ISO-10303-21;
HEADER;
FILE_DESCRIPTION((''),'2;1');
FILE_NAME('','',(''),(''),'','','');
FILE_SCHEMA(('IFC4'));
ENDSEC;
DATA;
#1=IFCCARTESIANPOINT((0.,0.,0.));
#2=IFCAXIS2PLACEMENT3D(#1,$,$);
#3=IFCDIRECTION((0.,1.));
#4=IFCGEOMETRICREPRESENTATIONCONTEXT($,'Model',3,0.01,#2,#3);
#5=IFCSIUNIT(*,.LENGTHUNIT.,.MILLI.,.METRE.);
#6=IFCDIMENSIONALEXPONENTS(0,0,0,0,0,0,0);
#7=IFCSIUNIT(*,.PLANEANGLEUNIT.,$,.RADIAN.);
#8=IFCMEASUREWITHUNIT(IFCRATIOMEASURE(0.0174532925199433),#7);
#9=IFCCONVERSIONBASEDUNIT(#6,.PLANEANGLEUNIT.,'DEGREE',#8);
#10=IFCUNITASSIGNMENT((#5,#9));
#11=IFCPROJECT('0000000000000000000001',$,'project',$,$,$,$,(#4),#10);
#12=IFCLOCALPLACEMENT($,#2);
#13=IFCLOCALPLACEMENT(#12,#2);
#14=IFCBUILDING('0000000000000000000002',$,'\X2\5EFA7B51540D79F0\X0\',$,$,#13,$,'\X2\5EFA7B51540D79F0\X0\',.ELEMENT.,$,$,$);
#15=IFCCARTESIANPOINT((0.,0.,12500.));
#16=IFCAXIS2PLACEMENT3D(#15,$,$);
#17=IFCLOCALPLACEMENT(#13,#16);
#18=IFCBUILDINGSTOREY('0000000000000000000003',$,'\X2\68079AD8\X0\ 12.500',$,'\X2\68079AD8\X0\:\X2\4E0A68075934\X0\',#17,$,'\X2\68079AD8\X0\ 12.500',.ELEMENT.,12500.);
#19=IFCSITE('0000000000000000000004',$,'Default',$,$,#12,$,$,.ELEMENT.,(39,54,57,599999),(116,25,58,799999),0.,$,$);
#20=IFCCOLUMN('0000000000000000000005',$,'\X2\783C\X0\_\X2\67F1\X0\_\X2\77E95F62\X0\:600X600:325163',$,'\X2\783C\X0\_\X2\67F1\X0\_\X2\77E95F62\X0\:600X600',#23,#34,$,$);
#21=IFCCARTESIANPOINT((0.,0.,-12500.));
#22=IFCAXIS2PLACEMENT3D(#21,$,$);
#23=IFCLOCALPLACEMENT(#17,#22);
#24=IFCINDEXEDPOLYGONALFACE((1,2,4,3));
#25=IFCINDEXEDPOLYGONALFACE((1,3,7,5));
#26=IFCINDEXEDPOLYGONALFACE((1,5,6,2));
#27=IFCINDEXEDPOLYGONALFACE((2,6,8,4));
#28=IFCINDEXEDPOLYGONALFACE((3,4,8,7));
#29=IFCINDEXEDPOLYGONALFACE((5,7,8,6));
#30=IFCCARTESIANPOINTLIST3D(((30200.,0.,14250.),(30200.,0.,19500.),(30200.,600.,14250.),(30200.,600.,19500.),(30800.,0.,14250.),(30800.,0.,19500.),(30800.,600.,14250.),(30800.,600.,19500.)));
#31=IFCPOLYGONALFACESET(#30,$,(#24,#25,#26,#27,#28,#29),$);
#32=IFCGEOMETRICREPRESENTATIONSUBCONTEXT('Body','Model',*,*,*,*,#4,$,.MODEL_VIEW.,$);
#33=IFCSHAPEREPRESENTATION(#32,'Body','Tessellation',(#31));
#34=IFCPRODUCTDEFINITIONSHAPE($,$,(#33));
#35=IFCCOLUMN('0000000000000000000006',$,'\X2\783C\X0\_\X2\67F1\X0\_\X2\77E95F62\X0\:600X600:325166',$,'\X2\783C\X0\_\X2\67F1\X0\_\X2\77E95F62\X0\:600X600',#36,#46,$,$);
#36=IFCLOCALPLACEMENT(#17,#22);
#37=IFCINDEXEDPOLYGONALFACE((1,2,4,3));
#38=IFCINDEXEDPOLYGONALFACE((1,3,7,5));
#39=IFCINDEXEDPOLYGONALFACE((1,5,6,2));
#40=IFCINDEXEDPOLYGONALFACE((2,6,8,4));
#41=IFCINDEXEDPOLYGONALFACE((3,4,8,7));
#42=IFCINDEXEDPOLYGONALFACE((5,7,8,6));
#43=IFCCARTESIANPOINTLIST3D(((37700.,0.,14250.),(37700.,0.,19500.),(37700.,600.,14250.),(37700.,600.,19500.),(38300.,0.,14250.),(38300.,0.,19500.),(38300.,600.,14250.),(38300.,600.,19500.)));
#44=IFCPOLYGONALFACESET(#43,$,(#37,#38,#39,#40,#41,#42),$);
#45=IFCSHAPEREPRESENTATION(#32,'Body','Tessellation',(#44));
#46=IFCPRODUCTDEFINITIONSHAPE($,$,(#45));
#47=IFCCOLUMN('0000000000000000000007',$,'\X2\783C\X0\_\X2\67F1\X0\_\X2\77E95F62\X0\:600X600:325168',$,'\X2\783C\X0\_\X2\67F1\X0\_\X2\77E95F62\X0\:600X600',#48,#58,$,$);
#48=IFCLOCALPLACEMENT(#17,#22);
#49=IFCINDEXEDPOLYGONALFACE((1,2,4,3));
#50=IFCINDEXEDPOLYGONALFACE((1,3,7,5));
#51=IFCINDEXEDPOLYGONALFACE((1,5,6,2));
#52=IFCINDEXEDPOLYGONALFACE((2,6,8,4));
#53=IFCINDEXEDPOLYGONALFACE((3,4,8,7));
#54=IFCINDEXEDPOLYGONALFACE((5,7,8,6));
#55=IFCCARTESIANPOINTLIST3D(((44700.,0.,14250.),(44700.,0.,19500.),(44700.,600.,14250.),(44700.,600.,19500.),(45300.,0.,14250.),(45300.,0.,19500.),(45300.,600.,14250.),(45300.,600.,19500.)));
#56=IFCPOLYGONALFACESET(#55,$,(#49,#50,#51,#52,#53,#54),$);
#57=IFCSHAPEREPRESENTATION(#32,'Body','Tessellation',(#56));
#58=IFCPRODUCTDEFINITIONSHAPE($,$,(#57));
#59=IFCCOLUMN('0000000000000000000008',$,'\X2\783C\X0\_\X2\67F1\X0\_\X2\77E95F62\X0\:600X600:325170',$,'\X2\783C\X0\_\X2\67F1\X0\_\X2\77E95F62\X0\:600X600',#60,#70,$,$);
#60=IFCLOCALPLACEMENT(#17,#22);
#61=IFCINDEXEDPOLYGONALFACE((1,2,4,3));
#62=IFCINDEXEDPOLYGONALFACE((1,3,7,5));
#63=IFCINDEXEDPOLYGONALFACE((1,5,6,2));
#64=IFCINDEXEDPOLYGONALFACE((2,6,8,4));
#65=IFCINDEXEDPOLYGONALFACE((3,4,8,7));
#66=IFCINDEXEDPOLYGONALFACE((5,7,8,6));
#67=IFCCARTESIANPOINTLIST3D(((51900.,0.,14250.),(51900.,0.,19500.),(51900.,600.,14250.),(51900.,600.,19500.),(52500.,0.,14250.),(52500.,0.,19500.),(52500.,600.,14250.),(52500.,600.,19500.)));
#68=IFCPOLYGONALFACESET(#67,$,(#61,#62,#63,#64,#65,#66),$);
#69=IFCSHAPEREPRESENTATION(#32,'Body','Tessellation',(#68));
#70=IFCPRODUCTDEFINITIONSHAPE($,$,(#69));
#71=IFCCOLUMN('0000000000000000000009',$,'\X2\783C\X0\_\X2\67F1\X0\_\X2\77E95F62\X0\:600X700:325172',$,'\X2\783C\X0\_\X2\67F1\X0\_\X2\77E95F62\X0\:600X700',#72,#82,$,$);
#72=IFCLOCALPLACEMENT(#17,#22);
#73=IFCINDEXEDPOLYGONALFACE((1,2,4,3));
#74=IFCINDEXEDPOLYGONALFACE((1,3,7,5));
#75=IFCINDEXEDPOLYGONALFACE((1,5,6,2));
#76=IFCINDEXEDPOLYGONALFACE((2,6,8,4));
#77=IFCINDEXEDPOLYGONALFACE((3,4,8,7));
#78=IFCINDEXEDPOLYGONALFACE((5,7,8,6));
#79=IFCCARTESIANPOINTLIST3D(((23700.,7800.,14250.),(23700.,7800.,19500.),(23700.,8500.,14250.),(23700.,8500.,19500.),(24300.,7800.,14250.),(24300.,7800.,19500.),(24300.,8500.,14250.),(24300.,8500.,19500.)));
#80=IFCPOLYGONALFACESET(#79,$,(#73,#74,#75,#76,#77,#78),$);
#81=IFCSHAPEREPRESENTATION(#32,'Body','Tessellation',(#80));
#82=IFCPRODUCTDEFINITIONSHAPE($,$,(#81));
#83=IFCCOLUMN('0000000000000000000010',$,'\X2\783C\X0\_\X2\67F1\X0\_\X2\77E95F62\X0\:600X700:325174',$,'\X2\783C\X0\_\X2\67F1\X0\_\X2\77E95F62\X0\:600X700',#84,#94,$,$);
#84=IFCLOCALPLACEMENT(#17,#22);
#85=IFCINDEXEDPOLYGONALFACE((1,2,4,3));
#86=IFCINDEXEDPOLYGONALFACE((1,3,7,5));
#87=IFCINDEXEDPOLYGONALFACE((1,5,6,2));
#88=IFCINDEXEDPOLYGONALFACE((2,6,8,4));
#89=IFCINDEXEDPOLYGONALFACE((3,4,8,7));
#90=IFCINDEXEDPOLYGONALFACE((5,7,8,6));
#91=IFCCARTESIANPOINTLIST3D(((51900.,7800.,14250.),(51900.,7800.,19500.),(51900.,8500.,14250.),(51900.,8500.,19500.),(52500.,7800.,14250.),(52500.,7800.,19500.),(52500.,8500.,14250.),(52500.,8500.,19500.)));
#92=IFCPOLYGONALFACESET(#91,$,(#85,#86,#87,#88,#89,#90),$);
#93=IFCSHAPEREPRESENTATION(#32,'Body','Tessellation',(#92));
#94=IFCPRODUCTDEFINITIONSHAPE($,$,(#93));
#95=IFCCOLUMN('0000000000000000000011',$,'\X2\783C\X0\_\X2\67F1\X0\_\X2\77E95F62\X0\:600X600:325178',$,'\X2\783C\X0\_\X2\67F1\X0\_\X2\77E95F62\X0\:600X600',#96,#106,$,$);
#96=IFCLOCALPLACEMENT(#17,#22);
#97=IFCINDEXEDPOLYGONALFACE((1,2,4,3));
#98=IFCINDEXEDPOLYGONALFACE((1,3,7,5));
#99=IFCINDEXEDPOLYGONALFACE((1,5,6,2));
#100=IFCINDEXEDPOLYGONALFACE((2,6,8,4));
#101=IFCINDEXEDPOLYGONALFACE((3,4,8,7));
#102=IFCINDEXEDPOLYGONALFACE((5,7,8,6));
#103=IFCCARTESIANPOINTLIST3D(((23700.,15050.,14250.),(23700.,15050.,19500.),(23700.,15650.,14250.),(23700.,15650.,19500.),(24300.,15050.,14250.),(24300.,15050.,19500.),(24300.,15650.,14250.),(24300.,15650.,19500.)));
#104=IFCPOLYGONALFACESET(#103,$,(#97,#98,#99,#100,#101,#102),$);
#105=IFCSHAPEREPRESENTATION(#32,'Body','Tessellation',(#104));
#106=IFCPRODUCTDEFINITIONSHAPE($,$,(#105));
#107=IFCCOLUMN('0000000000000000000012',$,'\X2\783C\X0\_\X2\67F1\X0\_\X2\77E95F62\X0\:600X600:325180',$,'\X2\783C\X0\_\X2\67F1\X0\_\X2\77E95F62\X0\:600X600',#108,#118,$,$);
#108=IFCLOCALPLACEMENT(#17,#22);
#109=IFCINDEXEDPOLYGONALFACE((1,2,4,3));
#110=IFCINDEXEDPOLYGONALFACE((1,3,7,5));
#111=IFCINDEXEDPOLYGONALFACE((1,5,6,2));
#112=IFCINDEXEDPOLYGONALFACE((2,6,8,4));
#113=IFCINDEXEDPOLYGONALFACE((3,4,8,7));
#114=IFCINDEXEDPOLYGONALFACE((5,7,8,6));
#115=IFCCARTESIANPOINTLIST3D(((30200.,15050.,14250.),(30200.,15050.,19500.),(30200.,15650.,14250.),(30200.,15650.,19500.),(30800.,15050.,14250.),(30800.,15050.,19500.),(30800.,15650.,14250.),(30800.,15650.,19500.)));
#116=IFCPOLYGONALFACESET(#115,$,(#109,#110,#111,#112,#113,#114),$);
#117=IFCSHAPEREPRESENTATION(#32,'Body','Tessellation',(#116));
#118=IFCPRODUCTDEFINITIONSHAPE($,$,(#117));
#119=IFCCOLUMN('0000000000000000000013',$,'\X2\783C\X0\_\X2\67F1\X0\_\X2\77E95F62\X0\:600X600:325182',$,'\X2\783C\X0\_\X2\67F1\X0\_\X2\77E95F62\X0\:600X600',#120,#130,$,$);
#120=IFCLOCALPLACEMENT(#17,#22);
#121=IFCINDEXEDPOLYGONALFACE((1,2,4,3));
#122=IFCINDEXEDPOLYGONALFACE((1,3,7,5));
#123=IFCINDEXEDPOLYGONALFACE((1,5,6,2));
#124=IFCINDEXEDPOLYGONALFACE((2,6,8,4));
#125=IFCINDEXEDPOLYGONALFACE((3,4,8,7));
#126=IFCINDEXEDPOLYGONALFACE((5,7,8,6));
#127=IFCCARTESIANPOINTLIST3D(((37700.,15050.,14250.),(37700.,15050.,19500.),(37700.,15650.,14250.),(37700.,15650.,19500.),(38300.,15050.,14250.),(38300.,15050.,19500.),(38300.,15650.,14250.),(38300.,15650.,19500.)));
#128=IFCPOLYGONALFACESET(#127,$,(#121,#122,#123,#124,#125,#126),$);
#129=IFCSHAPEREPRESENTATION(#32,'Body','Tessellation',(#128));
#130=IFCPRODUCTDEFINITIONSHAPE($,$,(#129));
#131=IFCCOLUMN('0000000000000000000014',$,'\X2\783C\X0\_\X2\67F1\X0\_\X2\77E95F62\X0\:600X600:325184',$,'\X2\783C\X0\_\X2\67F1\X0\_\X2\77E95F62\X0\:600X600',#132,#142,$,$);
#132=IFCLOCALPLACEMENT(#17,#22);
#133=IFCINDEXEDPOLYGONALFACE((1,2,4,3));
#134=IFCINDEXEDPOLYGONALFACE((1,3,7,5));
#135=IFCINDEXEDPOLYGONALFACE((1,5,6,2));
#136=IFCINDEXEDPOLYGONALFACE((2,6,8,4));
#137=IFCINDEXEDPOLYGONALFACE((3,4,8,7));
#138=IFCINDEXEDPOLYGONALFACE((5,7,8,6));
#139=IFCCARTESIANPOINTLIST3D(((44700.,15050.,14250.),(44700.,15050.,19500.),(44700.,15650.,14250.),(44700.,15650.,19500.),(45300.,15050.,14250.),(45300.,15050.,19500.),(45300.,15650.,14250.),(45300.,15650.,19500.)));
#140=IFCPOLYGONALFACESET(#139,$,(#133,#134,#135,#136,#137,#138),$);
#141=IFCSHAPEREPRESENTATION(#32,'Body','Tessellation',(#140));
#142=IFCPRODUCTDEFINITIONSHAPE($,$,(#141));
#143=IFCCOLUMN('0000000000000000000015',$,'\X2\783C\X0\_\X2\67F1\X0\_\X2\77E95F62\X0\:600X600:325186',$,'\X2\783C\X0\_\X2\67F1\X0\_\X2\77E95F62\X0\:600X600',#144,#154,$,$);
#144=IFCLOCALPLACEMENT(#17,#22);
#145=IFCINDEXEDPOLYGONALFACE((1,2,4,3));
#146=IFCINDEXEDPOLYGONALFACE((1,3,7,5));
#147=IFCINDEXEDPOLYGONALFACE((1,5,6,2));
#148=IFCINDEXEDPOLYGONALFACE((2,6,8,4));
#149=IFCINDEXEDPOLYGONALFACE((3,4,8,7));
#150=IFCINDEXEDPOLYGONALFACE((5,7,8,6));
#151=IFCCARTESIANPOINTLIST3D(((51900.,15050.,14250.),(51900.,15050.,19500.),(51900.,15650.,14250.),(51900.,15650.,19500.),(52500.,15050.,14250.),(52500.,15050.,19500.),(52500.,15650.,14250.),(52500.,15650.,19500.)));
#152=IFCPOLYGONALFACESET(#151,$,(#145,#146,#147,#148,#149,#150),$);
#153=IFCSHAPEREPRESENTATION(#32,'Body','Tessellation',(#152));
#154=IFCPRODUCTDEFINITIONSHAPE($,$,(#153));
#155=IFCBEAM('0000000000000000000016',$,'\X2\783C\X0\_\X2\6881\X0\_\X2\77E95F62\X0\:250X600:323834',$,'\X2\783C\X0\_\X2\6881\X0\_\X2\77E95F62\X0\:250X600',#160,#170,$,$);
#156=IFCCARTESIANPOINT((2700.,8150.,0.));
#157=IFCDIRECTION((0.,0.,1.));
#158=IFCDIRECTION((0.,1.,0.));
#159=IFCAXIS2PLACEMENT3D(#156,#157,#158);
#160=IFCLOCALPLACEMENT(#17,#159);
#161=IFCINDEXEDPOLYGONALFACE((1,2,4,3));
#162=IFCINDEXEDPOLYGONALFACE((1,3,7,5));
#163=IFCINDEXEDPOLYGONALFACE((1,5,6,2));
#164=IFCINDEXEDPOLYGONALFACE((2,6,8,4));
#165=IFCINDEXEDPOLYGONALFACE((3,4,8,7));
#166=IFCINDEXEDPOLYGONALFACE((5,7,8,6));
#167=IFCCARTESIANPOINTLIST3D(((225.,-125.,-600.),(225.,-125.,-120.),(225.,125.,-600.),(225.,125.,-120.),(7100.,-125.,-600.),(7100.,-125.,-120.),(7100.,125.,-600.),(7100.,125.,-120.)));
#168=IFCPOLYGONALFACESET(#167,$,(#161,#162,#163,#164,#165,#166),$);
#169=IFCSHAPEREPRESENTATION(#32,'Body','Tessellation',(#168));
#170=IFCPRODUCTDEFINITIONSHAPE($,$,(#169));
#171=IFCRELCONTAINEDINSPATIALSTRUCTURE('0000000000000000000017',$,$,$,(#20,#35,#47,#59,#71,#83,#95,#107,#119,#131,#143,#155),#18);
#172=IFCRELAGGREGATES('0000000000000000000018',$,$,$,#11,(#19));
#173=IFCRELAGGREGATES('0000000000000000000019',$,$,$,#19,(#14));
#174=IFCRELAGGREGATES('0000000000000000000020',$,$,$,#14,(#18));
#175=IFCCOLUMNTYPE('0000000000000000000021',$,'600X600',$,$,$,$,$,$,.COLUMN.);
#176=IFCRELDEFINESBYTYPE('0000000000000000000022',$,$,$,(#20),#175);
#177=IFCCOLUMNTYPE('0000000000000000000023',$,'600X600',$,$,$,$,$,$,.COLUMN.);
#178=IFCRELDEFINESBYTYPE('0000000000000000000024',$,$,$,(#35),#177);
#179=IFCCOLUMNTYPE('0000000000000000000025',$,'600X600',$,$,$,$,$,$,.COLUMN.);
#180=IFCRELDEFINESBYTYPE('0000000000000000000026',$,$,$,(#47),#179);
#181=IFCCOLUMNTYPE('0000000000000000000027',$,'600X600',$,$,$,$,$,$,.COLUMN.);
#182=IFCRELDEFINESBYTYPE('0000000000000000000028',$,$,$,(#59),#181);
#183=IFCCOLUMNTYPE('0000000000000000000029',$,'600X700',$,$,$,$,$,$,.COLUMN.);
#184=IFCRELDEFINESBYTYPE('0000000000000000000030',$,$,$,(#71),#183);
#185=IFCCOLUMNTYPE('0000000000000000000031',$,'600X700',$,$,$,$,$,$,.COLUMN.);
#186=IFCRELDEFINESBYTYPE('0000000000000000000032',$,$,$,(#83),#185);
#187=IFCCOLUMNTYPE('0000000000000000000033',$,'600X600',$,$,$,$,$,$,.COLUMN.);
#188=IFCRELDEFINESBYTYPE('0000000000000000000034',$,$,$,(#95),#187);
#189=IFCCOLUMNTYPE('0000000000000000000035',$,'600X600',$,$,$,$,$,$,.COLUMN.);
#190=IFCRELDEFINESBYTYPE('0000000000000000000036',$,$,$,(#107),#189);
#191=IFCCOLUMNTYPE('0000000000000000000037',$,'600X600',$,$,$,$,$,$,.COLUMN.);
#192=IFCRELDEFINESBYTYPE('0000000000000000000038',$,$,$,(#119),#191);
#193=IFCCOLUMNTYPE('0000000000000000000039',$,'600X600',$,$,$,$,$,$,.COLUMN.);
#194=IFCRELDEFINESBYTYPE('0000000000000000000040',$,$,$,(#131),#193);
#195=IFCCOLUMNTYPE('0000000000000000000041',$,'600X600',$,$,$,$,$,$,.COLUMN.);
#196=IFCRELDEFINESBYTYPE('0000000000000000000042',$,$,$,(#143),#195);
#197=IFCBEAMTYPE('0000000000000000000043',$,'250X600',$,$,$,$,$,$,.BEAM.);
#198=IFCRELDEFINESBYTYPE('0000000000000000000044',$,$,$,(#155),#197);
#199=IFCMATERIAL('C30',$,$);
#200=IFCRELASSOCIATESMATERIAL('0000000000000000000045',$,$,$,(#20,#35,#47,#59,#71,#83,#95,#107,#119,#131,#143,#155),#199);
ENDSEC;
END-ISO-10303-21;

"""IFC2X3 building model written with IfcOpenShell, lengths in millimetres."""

from ifc_helpers import new_model, entity, si_unit, converted_unit, direction, frame, frame_2d, origin, origin_2d_with_axis, place, context, subcontext, project, spatial, rectangle, extrude, source, transform, mapped, material, type_object, type_shapes, element, save


model = new_model("IFC2X3")

# Units and contexts
model_context = context("Model", 3, precision=0.01, world=origin(), true_north=direction((0.0, 1.0)))
body_context = subcontext(model_context, "Body", "Model", "MODEL_VIEW")
ifc_project = project(units=[si_unit("LENGTHUNIT", "METRE", prefix="MILLI"), converted_unit("PLANEANGLEUNIT", "DEGREE", entity("IfcRatioMeasure", 0.0174532925199433), si_unit("PLANEANGLEUNIT", "RADIAN"), dimensions=[0, 0, 0, 0, 0, 0, 0])], contexts=[model_context])

# Site, building, storey
site_placement = place(None, origin())
site = spatial("IfcSite", under=ifc_project, at=site_placement, Name="Default", CompositionType="ELEMENT", RefLatitude=(39, 54, 57, 599999), RefLongitude=(116, 25, 58, 799999), RefElevation=0.0)
building_placement = place(site_placement, origin())
building = spatial("IfcBuilding", under=site, at=building_placement, Name="建筑名称", LongName="建筑名称", CompositionType="ELEMENT")
storey_placement = place(building_placement, frame((0.0, 0.0, 12500.0)))
storey = spatial("IfcBuildingStorey", under=building, at=storey_placement, Name="标高 12.500", ObjectType="标高:上标头", LongName="标高 12.500", CompositionType="ELEMENT", Elevation=12500.0)

# Columns
ifc_material = material(Name="C30")
column_type_1 = type_object("IfcColumnType", Name="600X600", PredefinedType="COLUMN")
shared_shape_1 = source(origin(), body_context, "Body", "SweptSolid", [
    extrude(rectangle(XDim=600.0, YDim=600.0, at=origin_2d_with_axis()), frame((30500.0, 300.0, 14250.0), z_axis=(0.0, 0.0, 1.0), x_axis=(0.0, -1.0, 0.0)), (0.0, 0.0, 1.0), 5250.0),
])
type_shapes(column_type_1, [shared_shape_1])
column_1_placement = place(storey_placement, frame((0.0, 0.0, -12500.0)))
element("IfcColumn", 1, at=column_1_placement, inside=storey, type_object=column_type_1, material=ifc_material, Name="砼_柱_矩形:600X600:325163", ObjectType="砼_柱_矩形:600X600", context=body_context, shape_type="MappedRepresentation", body=[
    mapped(shared_shape_1, transform((0.0, 0.0, 0.0), scale=1.0)),
])
column_type_2 = type_object("IfcColumnType", Name="600X600", PredefinedType="COLUMN")
shared_shape_2 = source(origin(), body_context, "Body", "SweptSolid", [
    extrude(rectangle(XDim=600.0, YDim=600.0, at=origin_2d_with_axis()), frame((38000.0, 300.0, 14250.0), z_axis=(0.0, 0.0, 1.0), x_axis=(0.0, -1.0, 0.0)), (0.0, 0.0, 1.0), 5250.0),
])
type_shapes(column_type_2, [shared_shape_2])
column_2_placement = place(storey_placement, frame((0.0, 0.0, -12500.0)))
element("IfcColumn", 2, at=column_2_placement, inside=storey, type_object=column_type_2, material=ifc_material, Name="砼_柱_矩形:600X600:325166", ObjectType="砼_柱_矩形:600X600", context=body_context, shape_type="MappedRepresentation", body=[
    mapped(shared_shape_2, transform((0.0, 0.0, 0.0), scale=1.0)),
])
column_type_3 = type_object("IfcColumnType", Name="600X600", PredefinedType="COLUMN")
shared_shape_3 = source(origin(), body_context, "Body", "SweptSolid", [
    extrude(rectangle(XDim=600.0, YDim=600.0, at=origin_2d_with_axis()), frame((45000.0, 300.0, 14250.0), z_axis=(0.0, 0.0, 1.0), x_axis=(0.0, -1.0, 0.0)), (0.0, 0.0, 1.0), 5250.0),
])
type_shapes(column_type_3, [shared_shape_3])
column_3_placement = place(storey_placement, frame((0.0, 0.0, -12500.0)))
element("IfcColumn", 3, at=column_3_placement, inside=storey, type_object=column_type_3, material=ifc_material, Name="砼_柱_矩形:600X600:325168", ObjectType="砼_柱_矩形:600X600", context=body_context, shape_type="MappedRepresentation", body=[
    mapped(shared_shape_3, transform((0.0, 0.0, 0.0), scale=1.0)),
])
column_type_4 = type_object("IfcColumnType", Name="600X600", PredefinedType="COLUMN")
shared_shape_4 = source(origin(), body_context, "Body", "SweptSolid", [
    extrude(rectangle(XDim=600.0, YDim=600.0, at=origin_2d_with_axis()), frame((52200.0, 300.0, 14250.0), z_axis=(0.0, 0.0, 1.0), x_axis=(0.0, -1.0, 0.0)), (0.0, 0.0, 1.0), 5250.0),
])
type_shapes(column_type_4, [shared_shape_4])
column_4_placement = place(storey_placement, frame((0.0, 0.0, -12500.0)))
element("IfcColumn", 4, at=column_4_placement, inside=storey, type_object=column_type_4, material=ifc_material, Name="砼_柱_矩形:600X600:325170", ObjectType="砼_柱_矩形:600X600", context=body_context, shape_type="MappedRepresentation", body=[
    mapped(shared_shape_4, transform((0.0, 0.0, 0.0), scale=1.0)),
])
column_type_5 = type_object("IfcColumnType", Name="600X700", PredefinedType="COLUMN")
shared_shape_5 = source(origin(), body_context, "Body", "SweptSolid", [
    extrude(rectangle(XDim=700.0, YDim=600.0, at=origin_2d_with_axis()), frame((24000.0, 8150.0, 14250.0), z_axis=(0.0, 0.0, 1.0), x_axis=(0.0, -1.0, 0.0)), (0.0, 0.0, 1.0), 5250.0),
])
type_shapes(column_type_5, [shared_shape_5])
column_5_placement = place(storey_placement, frame((0.0, 0.0, -12500.0)))
element("IfcColumn", 5, at=column_5_placement, inside=storey, type_object=column_type_5, material=ifc_material, Name="砼_柱_矩形:600X700:325172", ObjectType="砼_柱_矩形:600X700", context=body_context, shape_type="MappedRepresentation", body=[
    mapped(shared_shape_5, transform((0.0, 0.0, 0.0), scale=1.0)),
])
column_type_6 = type_object("IfcColumnType", Name="600X700", PredefinedType="COLUMN")
shared_shape_6 = source(origin(), body_context, "Body", "SweptSolid", [
    extrude(rectangle(XDim=700.0, YDim=600.0, at=origin_2d_with_axis()), frame((52200.0, 8150.0, 14250.0), z_axis=(0.0, 0.0, 1.0), x_axis=(0.0, -1.0, 0.0)), (0.0, 0.0, 1.0), 5250.0),
])
type_shapes(column_type_6, [shared_shape_6])
column_6_placement = place(storey_placement, frame((0.0, 0.0, -12500.0)))
element("IfcColumn", 6, at=column_6_placement, inside=storey, type_object=column_type_6, material=ifc_material, Name="砼_柱_矩形:600X700:325174", ObjectType="砼_柱_矩形:600X700", context=body_context, shape_type="MappedRepresentation", body=[
    mapped(shared_shape_6, transform((0.0, 0.0, 0.0), scale=1.0)),
])
column_type_7 = type_object("IfcColumnType", Name="600X600", PredefinedType="COLUMN")
shared_shape_7 = source(origin(), body_context, "Body", "SweptSolid", [
    extrude(rectangle(XDim=600.0, YDim=600.0, at=origin_2d_with_axis()), frame((24000.0, 15350.0, 14250.0), z_axis=(0.0, 0.0, 1.0), x_axis=(0.0, -1.0, 0.0)), (0.0, 0.0, 1.0), 5250.0),
])
type_shapes(column_type_7, [shared_shape_7])
column_7_placement = place(storey_placement, frame((0.0, 0.0, -12500.0)))
element("IfcColumn", 7, at=column_7_placement, inside=storey, type_object=column_type_7, material=ifc_material, Name="砼_柱_矩形:600X600:325178", ObjectType="砼_柱_矩形:600X600", context=body_context, shape_type="MappedRepresentation", body=[
    mapped(shared_shape_7, transform((0.0, 0.0, 0.0), scale=1.0)),
])
column_type_8 = type_object("IfcColumnType", Name="600X600", PredefinedType="COLUMN")
shared_shape_8 = source(origin(), body_context, "Body", "SweptSolid", [
    extrude(rectangle(XDim=600.0, YDim=600.0, at=origin_2d_with_axis()), frame((30500.0, 15350.0, 14250.0), z_axis=(0.0, 0.0, 1.0), x_axis=(0.0, -1.0, 0.0)), (0.0, 0.0, 1.0), 5250.0),
])
type_shapes(column_type_8, [shared_shape_8])
column_8_placement = place(storey_placement, frame((0.0, 0.0, -12500.0)))
element("IfcColumn", 8, at=column_8_placement, inside=storey, type_object=column_type_8, material=ifc_material, Name="砼_柱_矩形:600X600:325180", ObjectType="砼_柱_矩形:600X600", context=body_context, shape_type="MappedRepresentation", body=[
    mapped(shared_shape_8, transform((0.0, 0.0, 0.0), scale=1.0)),
])
column_type_9 = type_object("IfcColumnType", Name="600X600", PredefinedType="COLUMN")
shared_shape_9 = source(origin(), body_context, "Body", "SweptSolid", [
    extrude(rectangle(XDim=600.0, YDim=600.0, at=origin_2d_with_axis()), frame((38000.0, 15350.0, 14250.0), z_axis=(0.0, 0.0, 1.0), x_axis=(0.0, -1.0, 0.0)), (0.0, 0.0, 1.0), 5250.0),
])
type_shapes(column_type_9, [shared_shape_9])
column_9_placement = place(storey_placement, frame((0.0, 0.0, -12500.0)))
element("IfcColumn", 9, at=column_9_placement, inside=storey, type_object=column_type_9, material=ifc_material, Name="砼_柱_矩形:600X600:325182", ObjectType="砼_柱_矩形:600X600", context=body_context, shape_type="MappedRepresentation", body=[
    mapped(shared_shape_9, transform((0.0, 0.0, 0.0), scale=1.0)),
])
column_type_10 = type_object("IfcColumnType", Name="600X600", PredefinedType="COLUMN")
shared_shape_10 = source(origin(), body_context, "Body", "SweptSolid", [
    extrude(rectangle(XDim=600.0, YDim=600.0, at=origin_2d_with_axis()), frame((45000.0, 15350.0, 14250.0), z_axis=(0.0, 0.0, 1.0), x_axis=(0.0, -1.0, 0.0)), (0.0, 0.0, 1.0), 5250.0),
])
type_shapes(column_type_10, [shared_shape_10])
column_10_placement = place(storey_placement, frame((0.0, 0.0, -12500.0)))
element("IfcColumn", 10, at=column_10_placement, inside=storey, type_object=column_type_10, material=ifc_material, Name="砼_柱_矩形:600X600:325184", ObjectType="砼_柱_矩形:600X600", context=body_context, shape_type="MappedRepresentation", body=[
    mapped(shared_shape_10, transform((0.0, 0.0, 0.0), scale=1.0)),
])
column_type_11 = type_object("IfcColumnType", Name="600X600", PredefinedType="COLUMN")
shared_shape_11 = source(origin(), body_context, "Body", "SweptSolid", [
    extrude(rectangle(XDim=600.0, YDim=600.0, at=origin_2d_with_axis()), frame((52200.0, 15350.0, 14250.0), z_axis=(0.0, 0.0, 1.0), x_axis=(0.0, -1.0, 0.0)), (0.0, 0.0, 1.0), 5250.0),
])
type_shapes(column_type_11, [shared_shape_11])
column_11_placement = place(storey_placement, frame((0.0, 0.0, -12500.0)))
element("IfcColumn", 11, at=column_11_placement, inside=storey, type_object=column_type_11, material=ifc_material, Name="砼_柱_矩形:600X600:325186", ObjectType="砼_柱_矩形:600X600", context=body_context, shape_type="MappedRepresentation", body=[
    mapped(shared_shape_11, transform((0.0, 0.0, 0.0), scale=1.0)),
])

# Beam
beam_type_1 = type_object("IfcBeamType", Name="250X600", PredefinedType="BEAM")
beam_1_placement = place(storey_placement, frame((2700.0, 8150.0, 0.0), z_axis=(0.0, 0.0, 1.0), x_axis=(0.0, 1.0, 0.0)))
element("IfcBeam", 12, at=beam_1_placement, inside=storey, type_object=beam_type_1, material=ifc_material, Name="砼_梁_矩形:250X600:323834", ObjectType="砼_梁_矩形:250X600", context=body_context, shape_type="SweptSolid", body=[
    extrude(rectangle(XDim=480.0, YDim=250.0, at=frame_2d((0.0, 0.0), x_axis=(1.0, 0.0))), frame((225.0, 0.0, -360.0), z_axis=(1.0, 0.0, 0.0), x_axis=(0.0, 0.0, -1.0)), (0.0, 0.0, 1.0), 6875.0),
])

save(model, "model.ifc")
